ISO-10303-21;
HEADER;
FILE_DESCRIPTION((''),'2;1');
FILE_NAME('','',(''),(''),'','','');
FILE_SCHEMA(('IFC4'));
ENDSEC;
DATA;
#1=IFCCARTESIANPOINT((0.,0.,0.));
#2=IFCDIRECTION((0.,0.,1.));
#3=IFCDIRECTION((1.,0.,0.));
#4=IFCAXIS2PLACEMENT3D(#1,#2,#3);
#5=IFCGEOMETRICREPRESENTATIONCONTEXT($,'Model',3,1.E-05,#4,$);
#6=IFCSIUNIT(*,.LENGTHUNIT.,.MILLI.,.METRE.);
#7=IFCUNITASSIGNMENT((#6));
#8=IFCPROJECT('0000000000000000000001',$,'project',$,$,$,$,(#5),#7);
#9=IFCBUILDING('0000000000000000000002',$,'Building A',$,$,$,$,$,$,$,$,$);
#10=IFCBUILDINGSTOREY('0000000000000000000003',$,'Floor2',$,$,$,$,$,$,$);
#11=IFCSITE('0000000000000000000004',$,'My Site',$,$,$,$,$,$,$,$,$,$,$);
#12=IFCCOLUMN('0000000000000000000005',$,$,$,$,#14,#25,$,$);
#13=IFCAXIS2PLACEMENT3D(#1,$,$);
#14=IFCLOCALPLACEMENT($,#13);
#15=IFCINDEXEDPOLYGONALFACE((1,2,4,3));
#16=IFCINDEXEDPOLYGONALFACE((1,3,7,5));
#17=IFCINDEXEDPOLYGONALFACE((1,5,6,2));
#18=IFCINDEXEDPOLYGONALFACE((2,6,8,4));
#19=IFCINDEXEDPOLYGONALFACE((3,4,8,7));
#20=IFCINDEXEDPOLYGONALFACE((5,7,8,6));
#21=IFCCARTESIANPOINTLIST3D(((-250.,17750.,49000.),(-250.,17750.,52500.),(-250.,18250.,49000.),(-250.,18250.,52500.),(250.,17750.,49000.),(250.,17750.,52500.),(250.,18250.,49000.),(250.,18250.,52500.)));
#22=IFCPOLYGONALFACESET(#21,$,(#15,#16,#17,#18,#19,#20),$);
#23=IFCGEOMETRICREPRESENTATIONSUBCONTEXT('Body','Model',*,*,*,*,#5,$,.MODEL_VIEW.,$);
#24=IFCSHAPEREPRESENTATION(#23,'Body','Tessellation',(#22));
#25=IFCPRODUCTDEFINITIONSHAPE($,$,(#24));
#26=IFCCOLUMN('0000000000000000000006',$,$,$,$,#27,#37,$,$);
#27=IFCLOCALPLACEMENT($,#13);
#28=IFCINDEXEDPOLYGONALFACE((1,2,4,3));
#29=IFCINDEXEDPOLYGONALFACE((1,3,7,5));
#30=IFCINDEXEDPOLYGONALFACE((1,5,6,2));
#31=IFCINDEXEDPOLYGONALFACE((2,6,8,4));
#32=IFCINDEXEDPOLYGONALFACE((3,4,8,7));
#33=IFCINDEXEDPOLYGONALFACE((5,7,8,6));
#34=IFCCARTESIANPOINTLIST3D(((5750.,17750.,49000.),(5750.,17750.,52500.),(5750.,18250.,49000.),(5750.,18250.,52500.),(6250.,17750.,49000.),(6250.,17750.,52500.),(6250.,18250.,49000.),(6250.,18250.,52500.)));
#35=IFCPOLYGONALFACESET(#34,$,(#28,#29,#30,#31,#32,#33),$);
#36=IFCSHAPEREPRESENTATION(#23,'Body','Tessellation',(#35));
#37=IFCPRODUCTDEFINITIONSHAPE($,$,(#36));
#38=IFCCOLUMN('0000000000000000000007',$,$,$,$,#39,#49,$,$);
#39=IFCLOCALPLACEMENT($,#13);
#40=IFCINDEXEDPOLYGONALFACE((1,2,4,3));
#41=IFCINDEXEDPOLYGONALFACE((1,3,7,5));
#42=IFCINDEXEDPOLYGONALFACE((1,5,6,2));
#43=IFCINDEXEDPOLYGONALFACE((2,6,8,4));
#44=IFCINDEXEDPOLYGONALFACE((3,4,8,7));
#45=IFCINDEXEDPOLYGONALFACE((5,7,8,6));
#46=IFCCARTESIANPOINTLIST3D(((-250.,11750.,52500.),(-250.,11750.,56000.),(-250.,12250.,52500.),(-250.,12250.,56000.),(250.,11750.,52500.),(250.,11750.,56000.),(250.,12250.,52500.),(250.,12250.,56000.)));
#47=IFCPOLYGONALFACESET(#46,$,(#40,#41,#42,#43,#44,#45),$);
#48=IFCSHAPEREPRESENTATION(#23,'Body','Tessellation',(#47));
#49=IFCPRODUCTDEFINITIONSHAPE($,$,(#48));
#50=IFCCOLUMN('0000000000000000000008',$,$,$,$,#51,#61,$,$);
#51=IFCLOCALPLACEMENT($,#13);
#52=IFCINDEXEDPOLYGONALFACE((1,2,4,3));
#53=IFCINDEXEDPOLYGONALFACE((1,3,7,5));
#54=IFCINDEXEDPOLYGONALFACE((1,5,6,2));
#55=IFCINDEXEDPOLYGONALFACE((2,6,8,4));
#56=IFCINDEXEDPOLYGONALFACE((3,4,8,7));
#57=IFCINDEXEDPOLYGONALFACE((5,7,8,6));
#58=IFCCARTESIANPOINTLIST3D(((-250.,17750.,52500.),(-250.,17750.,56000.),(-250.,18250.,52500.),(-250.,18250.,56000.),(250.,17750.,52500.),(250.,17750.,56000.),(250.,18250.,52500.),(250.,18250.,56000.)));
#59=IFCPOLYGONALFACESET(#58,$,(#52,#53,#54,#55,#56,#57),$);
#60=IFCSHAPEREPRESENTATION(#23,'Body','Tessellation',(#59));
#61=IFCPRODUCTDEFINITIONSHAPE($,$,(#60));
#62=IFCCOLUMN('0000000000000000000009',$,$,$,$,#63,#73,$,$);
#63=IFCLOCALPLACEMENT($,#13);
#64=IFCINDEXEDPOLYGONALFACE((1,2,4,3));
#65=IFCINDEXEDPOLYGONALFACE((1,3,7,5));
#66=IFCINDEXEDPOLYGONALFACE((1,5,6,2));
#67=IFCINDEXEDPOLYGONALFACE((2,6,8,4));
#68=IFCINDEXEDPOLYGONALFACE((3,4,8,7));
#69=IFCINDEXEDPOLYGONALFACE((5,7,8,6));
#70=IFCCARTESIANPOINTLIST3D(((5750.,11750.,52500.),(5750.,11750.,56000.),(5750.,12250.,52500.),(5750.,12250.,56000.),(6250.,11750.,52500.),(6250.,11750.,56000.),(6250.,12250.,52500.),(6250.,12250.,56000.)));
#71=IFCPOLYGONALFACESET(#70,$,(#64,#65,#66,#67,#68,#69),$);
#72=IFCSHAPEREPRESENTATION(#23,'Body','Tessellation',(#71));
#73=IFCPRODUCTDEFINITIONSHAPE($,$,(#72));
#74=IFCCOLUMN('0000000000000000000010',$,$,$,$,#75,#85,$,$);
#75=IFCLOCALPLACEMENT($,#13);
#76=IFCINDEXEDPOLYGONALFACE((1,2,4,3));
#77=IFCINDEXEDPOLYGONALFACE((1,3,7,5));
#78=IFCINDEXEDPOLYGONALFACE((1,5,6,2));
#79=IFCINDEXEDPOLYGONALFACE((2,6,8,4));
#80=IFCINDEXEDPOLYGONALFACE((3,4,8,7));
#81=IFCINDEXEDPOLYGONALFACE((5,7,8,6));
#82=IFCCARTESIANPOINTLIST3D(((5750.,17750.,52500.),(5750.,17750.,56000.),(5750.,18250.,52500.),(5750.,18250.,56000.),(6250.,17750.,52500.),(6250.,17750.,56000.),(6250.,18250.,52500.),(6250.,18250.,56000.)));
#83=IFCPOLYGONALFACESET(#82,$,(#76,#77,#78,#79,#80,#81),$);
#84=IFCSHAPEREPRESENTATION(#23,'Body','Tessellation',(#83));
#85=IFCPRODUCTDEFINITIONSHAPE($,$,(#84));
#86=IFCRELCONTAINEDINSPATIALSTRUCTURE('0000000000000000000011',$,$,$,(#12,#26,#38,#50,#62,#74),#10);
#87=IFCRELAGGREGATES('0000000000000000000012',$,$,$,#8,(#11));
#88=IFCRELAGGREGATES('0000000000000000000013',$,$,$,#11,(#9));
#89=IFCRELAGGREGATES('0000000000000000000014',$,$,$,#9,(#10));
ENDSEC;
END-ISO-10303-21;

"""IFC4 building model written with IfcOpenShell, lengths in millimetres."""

from ifc_helpers import new_model, si_unit, frame, origin_with_axes, place, context, subcontext, project, spatial, line, indexed_curve, outline, extrude, element, save


model = new_model("IFC4")

# Units and contexts
model_context = context("Model", 3, precision=1e-05, world=origin_with_axes())
body_context = subcontext(model_context, "Body", "Model", "MODEL_VIEW")
ifc_project = project(units=[si_unit("LENGTHUNIT", "METRE", prefix="MILLI")], contexts=[model_context])

# Site, building, storey
site = spatial("IfcSite", under=ifc_project, Name="My Site")
building = spatial("IfcBuilding", under=site, Name="Building A")
storey = spatial("IfcBuildingStorey", under=building, Name="Floor2")

# Columns
for number, where, z_axis, x_axis in (
    (1, (0.0, 18000.0, 49000.0), (0.0, 0.0, 1.0), (1.0, 0.0, 0.0)),
    (2, (6000.0, 18000.0, 49000.0), (0.0, 0.0, 1.0), (1.0, 0.0, 0.0)),
    (3, (0.0, 12000.0, 52500.0), (0.0, 0.0, 1.0), (1.0, 0.0, 0.0)),
    (4, (0.0, 18000.0, 52500.0), (0.0, 0.0, 1.0), (1.0, 0.0, 0.0)),
    (5, (6000.0, 12000.0, 52500.0), (0.0, 0.0, 1.0), (1.0, 0.0, 0.0)),
    (6, (6000.0, 18000.0, 52500.0), (0.0, 0.0, 1.0), (1.0, 0.0, 0.0)),
):
    element("IfcColumn", number, at=place(None, frame(where, z_axis=z_axis, x_axis=x_axis)), inside=storey, context=body_context, shape_type="SweptSolid", body=[
        extrude(outline(indexed_curve([(-250.0, -250.0), (250.0, -250.0), (250.0, 250.0), (-250.0, 250.0)], segments=[line(1, 2, 3, 4, 1)])), origin_with_axes(), (0.0, 0.0, 1.0), 3500.0),
    ])

save(model, "model.ifc")
